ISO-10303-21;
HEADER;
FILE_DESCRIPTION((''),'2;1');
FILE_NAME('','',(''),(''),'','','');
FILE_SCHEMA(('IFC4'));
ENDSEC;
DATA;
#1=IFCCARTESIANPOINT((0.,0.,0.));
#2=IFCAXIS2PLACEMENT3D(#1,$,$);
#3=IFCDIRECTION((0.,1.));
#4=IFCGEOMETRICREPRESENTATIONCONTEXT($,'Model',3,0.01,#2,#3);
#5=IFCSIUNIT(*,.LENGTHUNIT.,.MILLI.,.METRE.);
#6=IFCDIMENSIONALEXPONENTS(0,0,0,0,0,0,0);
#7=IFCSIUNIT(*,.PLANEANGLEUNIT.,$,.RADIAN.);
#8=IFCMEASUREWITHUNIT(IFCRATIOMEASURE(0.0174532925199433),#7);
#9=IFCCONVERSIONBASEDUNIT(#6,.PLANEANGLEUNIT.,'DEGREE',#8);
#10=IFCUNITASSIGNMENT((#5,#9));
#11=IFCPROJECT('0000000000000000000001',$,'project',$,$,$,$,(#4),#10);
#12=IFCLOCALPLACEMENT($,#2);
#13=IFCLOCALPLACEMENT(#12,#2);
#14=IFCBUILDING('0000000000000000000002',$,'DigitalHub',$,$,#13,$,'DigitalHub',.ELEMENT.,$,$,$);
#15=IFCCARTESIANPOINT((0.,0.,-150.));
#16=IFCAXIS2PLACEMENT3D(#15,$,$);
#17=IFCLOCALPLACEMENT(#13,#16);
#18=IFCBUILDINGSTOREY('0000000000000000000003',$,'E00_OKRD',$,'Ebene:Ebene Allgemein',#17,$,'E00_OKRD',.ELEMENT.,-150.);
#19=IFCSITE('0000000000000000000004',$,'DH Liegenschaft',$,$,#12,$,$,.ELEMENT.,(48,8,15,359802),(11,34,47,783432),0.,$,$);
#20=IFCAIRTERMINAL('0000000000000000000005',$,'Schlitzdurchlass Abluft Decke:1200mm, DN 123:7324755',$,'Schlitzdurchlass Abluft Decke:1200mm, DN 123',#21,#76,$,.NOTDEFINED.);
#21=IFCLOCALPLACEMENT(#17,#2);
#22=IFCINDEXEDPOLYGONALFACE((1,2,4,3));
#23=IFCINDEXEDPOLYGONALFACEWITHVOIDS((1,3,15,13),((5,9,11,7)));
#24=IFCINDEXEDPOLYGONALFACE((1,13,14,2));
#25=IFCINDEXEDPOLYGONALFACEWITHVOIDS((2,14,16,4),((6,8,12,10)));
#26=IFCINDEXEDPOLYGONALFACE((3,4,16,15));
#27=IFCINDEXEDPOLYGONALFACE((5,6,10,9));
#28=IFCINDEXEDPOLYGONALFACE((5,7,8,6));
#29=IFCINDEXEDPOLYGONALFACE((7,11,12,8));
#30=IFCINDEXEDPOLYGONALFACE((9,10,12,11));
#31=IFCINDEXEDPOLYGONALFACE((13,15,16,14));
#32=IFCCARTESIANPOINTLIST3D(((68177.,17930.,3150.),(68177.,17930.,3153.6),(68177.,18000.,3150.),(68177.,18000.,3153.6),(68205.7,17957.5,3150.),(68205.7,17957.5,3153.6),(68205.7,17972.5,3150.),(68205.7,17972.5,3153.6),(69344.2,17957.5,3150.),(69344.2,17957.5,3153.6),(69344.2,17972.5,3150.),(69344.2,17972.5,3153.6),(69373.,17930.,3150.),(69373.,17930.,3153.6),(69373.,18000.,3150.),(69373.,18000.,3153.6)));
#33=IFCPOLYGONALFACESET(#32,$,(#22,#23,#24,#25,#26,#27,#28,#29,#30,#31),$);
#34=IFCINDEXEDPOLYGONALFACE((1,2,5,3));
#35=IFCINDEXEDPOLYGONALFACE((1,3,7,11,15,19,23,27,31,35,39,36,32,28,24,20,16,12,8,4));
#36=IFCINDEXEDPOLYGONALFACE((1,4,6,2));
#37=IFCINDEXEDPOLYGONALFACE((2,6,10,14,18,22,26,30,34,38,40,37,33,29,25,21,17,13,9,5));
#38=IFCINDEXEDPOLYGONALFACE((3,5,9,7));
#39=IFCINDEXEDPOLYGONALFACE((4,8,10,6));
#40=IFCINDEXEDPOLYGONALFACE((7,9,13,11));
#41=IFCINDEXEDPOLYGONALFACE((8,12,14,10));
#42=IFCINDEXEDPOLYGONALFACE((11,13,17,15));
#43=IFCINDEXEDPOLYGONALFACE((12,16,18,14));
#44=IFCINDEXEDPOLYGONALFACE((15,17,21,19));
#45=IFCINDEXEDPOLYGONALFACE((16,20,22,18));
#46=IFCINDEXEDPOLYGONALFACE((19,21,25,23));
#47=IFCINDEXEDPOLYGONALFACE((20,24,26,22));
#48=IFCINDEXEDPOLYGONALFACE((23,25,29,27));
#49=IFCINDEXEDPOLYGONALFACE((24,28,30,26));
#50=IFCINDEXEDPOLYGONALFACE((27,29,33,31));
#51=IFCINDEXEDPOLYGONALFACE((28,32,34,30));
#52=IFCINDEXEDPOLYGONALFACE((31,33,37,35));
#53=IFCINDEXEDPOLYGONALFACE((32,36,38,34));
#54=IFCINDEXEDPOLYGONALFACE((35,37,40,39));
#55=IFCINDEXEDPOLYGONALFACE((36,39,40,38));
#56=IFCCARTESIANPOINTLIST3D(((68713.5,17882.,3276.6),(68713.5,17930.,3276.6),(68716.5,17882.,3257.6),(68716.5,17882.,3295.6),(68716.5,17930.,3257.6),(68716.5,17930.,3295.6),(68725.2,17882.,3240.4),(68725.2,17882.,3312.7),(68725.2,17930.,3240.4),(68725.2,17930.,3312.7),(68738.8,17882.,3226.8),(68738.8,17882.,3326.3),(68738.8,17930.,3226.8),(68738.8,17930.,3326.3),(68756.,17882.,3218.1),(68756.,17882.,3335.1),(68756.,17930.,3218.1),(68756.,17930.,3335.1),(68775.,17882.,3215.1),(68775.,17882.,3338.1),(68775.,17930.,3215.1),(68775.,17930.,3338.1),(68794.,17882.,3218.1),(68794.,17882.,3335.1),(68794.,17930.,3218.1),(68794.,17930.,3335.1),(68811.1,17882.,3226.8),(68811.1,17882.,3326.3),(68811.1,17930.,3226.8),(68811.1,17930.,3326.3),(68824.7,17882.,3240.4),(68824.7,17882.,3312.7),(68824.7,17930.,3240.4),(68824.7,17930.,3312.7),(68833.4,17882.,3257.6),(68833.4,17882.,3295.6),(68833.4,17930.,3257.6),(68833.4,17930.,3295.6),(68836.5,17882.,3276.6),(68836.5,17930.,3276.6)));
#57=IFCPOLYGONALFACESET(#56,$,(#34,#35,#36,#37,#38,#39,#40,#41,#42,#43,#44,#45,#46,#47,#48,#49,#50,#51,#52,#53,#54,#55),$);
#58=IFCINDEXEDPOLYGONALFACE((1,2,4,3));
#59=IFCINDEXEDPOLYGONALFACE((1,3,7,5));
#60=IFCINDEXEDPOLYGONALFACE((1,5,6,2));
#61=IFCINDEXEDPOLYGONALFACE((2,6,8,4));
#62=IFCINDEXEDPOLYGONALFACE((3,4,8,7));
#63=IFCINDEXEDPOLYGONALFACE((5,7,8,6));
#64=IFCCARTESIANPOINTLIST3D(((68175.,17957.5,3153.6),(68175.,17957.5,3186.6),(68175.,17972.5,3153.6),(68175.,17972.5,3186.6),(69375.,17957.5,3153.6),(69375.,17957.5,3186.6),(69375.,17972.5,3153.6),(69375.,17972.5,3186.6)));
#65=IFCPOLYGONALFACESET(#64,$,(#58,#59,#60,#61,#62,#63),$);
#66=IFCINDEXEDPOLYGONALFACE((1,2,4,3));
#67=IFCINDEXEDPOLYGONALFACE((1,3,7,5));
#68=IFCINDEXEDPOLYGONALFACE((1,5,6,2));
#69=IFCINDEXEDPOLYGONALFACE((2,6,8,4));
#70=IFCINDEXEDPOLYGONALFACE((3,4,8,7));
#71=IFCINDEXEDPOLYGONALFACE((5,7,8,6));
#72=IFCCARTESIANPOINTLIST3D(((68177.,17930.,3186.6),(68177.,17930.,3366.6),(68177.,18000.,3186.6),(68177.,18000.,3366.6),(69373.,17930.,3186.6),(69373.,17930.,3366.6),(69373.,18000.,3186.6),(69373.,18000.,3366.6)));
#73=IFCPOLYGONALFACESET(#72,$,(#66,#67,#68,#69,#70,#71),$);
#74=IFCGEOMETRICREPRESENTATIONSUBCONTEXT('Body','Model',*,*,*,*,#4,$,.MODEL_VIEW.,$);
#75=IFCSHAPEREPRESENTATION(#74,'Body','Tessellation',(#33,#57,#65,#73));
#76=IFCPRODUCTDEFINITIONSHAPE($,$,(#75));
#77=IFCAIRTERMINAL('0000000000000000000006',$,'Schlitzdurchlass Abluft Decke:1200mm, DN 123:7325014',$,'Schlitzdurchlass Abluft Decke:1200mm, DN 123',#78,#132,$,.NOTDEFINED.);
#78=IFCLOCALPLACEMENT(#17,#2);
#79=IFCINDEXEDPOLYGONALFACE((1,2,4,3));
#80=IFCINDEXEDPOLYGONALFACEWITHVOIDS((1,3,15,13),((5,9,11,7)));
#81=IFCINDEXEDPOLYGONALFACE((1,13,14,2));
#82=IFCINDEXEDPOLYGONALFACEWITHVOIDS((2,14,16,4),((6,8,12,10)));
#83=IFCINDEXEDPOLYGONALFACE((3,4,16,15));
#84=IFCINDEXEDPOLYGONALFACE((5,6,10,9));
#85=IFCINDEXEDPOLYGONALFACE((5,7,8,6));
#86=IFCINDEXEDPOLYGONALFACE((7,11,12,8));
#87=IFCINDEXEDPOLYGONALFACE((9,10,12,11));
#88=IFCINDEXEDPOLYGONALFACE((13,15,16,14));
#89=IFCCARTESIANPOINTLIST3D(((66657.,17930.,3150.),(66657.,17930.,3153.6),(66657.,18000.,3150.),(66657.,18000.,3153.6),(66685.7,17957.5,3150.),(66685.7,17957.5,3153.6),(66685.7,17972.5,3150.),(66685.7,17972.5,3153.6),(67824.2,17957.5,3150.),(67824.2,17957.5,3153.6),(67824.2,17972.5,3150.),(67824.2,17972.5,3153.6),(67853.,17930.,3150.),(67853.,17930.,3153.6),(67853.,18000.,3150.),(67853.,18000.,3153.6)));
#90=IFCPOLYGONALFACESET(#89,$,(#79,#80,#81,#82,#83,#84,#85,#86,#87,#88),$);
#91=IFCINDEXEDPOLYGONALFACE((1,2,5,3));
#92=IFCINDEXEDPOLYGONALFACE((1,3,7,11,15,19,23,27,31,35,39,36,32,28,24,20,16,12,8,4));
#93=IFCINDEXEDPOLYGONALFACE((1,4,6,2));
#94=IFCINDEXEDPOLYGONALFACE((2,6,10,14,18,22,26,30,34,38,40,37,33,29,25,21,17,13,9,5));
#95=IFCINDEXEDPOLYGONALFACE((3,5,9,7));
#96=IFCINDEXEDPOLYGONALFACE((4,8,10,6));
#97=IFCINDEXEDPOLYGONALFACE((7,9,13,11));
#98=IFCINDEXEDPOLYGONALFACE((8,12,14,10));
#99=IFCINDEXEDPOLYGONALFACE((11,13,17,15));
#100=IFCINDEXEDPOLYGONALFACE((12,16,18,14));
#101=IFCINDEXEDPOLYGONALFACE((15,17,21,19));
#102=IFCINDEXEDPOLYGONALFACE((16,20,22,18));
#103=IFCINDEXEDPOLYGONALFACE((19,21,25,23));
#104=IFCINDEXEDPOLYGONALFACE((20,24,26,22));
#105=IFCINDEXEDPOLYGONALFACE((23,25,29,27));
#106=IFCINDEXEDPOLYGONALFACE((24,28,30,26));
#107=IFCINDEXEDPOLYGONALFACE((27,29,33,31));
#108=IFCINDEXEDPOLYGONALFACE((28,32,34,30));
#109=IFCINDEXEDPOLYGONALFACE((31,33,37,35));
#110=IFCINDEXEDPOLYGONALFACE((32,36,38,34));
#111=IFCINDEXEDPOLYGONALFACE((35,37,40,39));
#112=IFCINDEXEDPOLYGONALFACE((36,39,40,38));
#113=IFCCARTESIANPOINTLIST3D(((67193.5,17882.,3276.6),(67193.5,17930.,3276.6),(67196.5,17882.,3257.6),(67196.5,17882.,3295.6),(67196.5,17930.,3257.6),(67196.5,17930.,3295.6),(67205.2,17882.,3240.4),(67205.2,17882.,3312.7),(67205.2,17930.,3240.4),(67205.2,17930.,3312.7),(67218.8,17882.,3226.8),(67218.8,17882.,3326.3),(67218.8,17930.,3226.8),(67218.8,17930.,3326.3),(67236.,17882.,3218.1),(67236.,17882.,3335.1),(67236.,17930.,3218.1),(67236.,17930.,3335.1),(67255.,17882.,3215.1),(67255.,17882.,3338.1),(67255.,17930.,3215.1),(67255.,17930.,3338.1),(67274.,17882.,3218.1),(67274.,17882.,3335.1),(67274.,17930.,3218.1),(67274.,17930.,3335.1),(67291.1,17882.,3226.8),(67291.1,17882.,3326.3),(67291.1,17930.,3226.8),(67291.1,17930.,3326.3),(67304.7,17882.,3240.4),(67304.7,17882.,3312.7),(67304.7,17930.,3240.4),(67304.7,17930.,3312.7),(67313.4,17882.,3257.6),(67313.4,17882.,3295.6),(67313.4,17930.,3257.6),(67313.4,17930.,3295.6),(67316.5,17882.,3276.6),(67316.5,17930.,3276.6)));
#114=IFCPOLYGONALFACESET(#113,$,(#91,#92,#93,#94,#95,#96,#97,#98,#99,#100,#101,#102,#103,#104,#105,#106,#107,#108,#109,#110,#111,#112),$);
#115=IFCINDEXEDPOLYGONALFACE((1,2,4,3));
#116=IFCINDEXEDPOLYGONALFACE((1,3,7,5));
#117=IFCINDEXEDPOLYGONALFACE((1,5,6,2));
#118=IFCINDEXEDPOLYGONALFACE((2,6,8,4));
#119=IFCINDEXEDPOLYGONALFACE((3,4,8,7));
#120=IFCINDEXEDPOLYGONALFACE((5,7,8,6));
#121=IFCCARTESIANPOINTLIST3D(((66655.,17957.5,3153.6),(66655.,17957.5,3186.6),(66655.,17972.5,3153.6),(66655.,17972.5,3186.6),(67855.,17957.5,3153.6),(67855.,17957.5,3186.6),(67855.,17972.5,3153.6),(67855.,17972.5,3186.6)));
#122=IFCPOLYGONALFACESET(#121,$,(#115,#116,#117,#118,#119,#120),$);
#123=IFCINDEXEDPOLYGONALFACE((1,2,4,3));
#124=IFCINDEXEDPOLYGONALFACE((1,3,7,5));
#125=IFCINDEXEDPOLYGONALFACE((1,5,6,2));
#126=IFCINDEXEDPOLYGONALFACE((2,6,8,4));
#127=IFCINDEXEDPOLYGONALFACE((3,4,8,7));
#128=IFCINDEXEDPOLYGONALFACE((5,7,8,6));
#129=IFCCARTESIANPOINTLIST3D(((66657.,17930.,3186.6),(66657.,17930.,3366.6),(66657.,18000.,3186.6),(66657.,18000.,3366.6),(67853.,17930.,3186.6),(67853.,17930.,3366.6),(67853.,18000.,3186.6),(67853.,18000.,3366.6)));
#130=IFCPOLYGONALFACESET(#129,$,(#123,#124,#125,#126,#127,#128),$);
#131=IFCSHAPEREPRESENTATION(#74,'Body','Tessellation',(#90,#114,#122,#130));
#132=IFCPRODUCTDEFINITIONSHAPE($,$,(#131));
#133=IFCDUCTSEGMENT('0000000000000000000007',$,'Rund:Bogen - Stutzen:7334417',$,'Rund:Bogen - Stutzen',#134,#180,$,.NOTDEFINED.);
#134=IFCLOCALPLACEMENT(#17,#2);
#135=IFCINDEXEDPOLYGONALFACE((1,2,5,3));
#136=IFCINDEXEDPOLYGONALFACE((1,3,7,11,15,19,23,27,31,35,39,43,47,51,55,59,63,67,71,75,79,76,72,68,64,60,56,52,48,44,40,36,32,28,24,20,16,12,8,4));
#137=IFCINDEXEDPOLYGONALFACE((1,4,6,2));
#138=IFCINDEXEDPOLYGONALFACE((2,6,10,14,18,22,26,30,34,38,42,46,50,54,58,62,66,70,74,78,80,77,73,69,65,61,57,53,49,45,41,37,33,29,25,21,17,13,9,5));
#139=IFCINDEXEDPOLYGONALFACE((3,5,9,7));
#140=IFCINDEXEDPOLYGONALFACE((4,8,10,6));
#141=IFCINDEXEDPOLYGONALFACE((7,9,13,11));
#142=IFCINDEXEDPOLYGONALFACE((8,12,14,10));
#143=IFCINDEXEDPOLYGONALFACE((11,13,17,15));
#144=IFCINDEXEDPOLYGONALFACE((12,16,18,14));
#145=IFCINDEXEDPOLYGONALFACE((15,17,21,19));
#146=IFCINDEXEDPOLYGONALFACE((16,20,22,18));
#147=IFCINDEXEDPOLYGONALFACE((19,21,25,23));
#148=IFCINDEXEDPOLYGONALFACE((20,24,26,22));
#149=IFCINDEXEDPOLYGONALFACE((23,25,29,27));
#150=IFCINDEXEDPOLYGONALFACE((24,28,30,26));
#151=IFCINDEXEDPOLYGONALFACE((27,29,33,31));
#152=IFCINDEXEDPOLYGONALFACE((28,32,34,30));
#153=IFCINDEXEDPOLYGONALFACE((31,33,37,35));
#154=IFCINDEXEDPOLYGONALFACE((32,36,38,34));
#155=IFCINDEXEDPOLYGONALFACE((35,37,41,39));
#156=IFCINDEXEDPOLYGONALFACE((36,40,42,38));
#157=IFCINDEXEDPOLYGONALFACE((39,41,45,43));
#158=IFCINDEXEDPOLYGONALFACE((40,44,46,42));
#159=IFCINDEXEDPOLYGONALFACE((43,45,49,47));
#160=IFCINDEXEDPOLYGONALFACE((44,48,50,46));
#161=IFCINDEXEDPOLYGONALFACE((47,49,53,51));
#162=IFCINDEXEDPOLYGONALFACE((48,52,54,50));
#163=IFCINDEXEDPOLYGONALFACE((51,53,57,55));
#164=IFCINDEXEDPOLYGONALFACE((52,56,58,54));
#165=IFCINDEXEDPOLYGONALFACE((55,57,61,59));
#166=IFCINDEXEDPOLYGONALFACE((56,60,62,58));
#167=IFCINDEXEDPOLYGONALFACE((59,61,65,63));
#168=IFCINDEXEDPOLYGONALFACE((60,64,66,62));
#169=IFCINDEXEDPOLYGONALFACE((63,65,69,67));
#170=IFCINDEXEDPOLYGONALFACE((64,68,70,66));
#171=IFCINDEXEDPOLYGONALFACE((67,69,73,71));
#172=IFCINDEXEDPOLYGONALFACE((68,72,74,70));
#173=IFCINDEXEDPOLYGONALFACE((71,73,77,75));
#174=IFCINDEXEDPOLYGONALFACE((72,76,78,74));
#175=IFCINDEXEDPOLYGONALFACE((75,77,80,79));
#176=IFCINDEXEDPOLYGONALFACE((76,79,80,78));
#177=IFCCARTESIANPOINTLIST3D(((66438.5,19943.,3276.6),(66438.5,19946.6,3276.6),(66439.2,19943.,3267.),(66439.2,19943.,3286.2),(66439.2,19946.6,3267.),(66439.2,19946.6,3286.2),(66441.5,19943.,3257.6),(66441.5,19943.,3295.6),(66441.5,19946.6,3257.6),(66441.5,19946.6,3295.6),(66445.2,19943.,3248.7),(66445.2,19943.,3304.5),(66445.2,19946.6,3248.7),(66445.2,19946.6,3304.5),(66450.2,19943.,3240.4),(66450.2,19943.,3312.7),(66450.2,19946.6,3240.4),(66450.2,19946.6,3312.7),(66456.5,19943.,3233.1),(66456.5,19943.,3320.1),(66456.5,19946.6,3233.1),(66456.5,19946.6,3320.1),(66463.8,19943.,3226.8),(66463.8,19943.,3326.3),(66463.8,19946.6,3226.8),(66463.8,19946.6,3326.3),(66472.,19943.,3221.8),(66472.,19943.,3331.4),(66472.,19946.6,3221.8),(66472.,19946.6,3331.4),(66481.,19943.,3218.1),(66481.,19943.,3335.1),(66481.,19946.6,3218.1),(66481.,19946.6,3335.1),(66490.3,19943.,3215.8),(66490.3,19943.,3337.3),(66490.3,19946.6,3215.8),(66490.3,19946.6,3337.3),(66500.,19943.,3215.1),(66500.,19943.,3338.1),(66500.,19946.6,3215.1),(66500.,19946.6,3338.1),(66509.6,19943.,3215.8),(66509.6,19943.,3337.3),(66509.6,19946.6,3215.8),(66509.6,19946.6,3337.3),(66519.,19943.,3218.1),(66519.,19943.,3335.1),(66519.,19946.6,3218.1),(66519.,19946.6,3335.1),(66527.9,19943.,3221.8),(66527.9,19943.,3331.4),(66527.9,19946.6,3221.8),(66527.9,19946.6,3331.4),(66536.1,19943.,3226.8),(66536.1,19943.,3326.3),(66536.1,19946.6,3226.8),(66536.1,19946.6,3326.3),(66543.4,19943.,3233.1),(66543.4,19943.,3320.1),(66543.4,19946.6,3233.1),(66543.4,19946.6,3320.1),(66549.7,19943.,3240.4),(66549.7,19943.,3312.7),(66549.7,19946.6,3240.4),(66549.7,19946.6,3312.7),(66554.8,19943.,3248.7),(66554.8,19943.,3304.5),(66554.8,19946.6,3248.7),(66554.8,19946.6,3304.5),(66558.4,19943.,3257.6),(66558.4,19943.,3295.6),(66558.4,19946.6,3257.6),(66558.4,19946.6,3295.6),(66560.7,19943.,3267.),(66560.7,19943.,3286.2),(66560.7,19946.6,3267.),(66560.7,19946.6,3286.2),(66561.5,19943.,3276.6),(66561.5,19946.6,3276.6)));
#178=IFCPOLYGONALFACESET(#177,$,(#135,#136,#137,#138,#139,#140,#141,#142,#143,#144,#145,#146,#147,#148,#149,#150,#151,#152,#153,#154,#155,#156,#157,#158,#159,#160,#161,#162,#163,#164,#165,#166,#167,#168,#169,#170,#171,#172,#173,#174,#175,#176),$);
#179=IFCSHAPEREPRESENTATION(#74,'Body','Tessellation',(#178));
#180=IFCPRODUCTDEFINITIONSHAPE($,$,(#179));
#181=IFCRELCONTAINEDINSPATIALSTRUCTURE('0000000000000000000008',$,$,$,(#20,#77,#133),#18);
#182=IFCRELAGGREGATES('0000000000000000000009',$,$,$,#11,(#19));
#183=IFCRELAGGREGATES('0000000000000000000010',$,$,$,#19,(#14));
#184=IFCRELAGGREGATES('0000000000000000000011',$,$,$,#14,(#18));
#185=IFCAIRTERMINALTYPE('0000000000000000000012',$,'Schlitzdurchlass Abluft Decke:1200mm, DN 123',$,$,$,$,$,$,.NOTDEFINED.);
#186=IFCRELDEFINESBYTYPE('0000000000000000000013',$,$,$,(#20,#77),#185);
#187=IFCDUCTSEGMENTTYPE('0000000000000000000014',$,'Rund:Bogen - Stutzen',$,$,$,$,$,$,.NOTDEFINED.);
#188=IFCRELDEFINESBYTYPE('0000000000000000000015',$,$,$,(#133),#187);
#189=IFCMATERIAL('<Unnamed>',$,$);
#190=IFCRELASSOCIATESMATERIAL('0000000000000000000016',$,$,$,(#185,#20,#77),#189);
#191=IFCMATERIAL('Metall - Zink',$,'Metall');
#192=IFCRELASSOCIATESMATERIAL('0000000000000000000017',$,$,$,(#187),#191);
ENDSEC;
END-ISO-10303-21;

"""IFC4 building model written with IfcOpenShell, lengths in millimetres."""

from ifc_helpers import new_model, entity, si_unit, converted_unit, direction, frame, origin, place, context, subcontext, project, spatial, indexed_curve, outline, extrude, source, transform, mapped, material, type_object, type_shapes, element, save


model = new_model("IFC4")

# Units and contexts
model_context = context("Model", 3, precision=0.01, world=origin(), true_north=direction((0.0, 1.0)))
body_context = subcontext(model_context, "Body", "Model", "MODEL_VIEW")
ifc_project = project(units=[si_unit("LENGTHUNIT", "METRE", prefix="MILLI"), converted_unit("PLANEANGLEUNIT", "DEGREE", entity("IfcRatioMeasure", 0.0174532925199433), si_unit("PLANEANGLEUNIT", "RADIAN"), dimensions=[0, 0, 0, 0, 0, 0, 0])], contexts=[model_context])

# Site, building, storey
site_placement = place(None, origin())
site = spatial("IfcSite", under=ifc_project, at=site_placement, Name="DH Liegenschaft", CompositionType="ELEMENT", RefLatitude=(48, 8, 15, 359802), RefLongitude=(11, 34, 47, 783432), RefElevation=0.0)
building_placement = place(site_placement, origin())
building = spatial("IfcBuilding", under=site, at=building_placement, Name="DigitalHub", LongName="DigitalHub", CompositionType="ELEMENT")
storey_placement = place(building_placement, frame((0.0, 0.0, -150.0)))
storey = spatial("IfcBuildingStorey", under=building, at=storey_placement, Name="E00_OKRD", ObjectType="Ebene:Ebene Allgemein", LongName="E00_OKRD", CompositionType="ELEMENT", Elevation=-150.0)

# Shared definitions
ifc_material_1 = material(Name="Metall - Zink", Category="Metall")

# Air terminals
ifc_material_2 = material(Name="<Unnamed>")
air_terminal_type_1 = type_object("IfcAirTerminalType", Name="Schlitzdurchlass Abluft Decke:1200mm, DN 123", PredefinedType="NOTDEFINED", material=ifc_material_2)
shared_shape_1 = source(origin(), body_context, "Body", "SweptSolid", [
    extrude(outline(indexed_curve([(-598.0, -35.0), (598.0, -35.0), (598.0, 35.0), (-598.0, 35.0), (-598.0, -35.0)], self_intersect=False), holes=[indexed_curve([(-569.2, -7.5), (-569.2, 7.5), (569.2, 7.5), (569.2, -7.5), (-569.2, -7.5)], self_intersect=False)]), frame((0.0, 0.0, 0.0), z_axis=(0.0, 0.0, 1.0), x_axis=(-1.0, 0.0, 0.0)), (0.0, 0.0, 1.0), 3.6),
    extrude(outline(indexed_curve([(61.5, 0.0), (58.5, 19.0), (49.8, 36.1), (36.1, 49.8), (19.0, 58.5), (0.0, 61.5), (-19.0, 58.5), (-36.1, 49.8), (-49.8, 36.1), (-58.5, 19.0), (-61.5, 0.0), (-58.5, -19.0), (-49.8, -36.1), (-36.1, -49.8), (-19.0, -58.5), (0.0, -61.5), (19.0, -58.5), (36.1, -49.8), (49.8, -36.1), (58.5, -19.0), (61.5, 0.0)], self_intersect=False)), frame((0.0, 35.0, 126.6), z_axis=(0.0, 1.0, 0.0), x_axis=(-1.0, 0.0, 0.0)), (0.0, 0.0, 1.0), 48.0),
    extrude(outline(indexed_curve([(-600.0, -7.5), (600.0, -7.5), (600.0, 7.5), (-600.0, 7.5), (-600.0, -7.5)], self_intersect=False)), frame((0.0, 0.0, 3.6), z_axis=(0.0, 0.0, 1.0), x_axis=(-1.0, 0.0, 0.0)), (0.0, 0.0, 1.0), 33.0),
    extrude(outline(indexed_curve([(-598.0, -35.0), (598.0, -35.0), (598.0, 35.0), (-598.0, 35.0), (-598.0, -35.0)], self_intersect=False)), frame((0.0, 0.0, 36.6), z_axis=(0.0, 0.0, 1.0), x_axis=(-1.0, 0.0, 0.0)), (0.0, 0.0, 1.0), 180.0),
])
type_shapes(air_terminal_type_1, [shared_shape_1])
for number, where, z_axis, x_axis, name in (
    (1, (68775.0, 17965.0, 3150.0), (0.0, 0.0, 1.0), (-1.0, 0.0, 0.0), "Schlitzdurchlass Abluft Decke:1200mm, DN 123:7324755"),
    (2, (67255.0, 17965.0, 3150.0), (0.0, 0.0, 1.0), (-1.0, 0.0, 0.0), "Schlitzdurchlass Abluft Decke:1200mm, DN 123:7325014"),
):
    element("IfcAirTerminal", number, at=place(storey_placement, frame(where, z_axis=z_axis, x_axis=x_axis)), inside=storey, type_object=air_terminal_type_1, material=ifc_material_2, Name=name, ObjectType="Schlitzdurchlass Abluft Decke:1200mm, DN 123", PredefinedType="NOTDEFINED", context=body_context, shape_type="MappedRepresentation", body=[
        mapped(shared_shape_1, transform((0.0, 0.0, 0.0), scale=1.0)),
    ])

# Duct segment
duct_segment_type_1 = type_object("IfcDuctSegmentType", Name="Rund:Bogen - Stutzen", PredefinedType="NOTDEFINED", material=ifc_material_1)
duct_segment_1_placement = place(storey_placement, frame((66436.9, 19943.0, 3213.5)))
element("IfcDuctSegment", 3, at=duct_segment_1_placement, inside=storey, type_object=duct_segment_type_1, Name="Rund:Bogen - Stutzen:7334417", ObjectType="Rund:Bogen - Stutzen", PredefinedType="NOTDEFINED", context=body_context, shape_type="SweptSolid", body=[
    extrude(outline(indexed_curve([(61.5, 0.0), (60.7, 9.6), (58.5, 19.0), (54.8, 27.9), (49.8, 36.1), (43.5, 43.5), (36.1, 49.8), (27.9, 54.8), (19.0, 58.5), (9.6, 60.7), (0.0, 61.5), (-9.6, 60.7), (-19.0, 58.5), (-27.9, 54.8), (-36.1, 49.8), (-43.5, 43.5), (-49.8, 36.1), (-54.8, 27.9), (-58.5, 19.0), (-60.7, 9.6), (-61.5, 0.0), (-60.7, -9.6), (-58.5, -19.0), (-54.8, -27.9), (-49.8, -36.1), (-43.5, -43.5), (-36.1, -49.8), (-27.9, -54.8), (-19.0, -58.5), (-9.6, -60.7), (0.0, -61.5), (9.6, -60.7), (19.0, -58.5), (27.9, -54.8), (36.1, -49.8), (43.5, -43.5), (49.8, -36.1), (54.8, -27.9), (58.5, -19.0), (60.7, -9.6), (61.5, 0.0)], self_intersect=False)), frame((63.1, 0.0, 63.1), z_axis=(0.0, 1.0, 0.0), x_axis=(-1.0, 0.0, 0.0)), (0.0, 0.0, 1.0), 3.6),
])

save(model, "model.ifc")
